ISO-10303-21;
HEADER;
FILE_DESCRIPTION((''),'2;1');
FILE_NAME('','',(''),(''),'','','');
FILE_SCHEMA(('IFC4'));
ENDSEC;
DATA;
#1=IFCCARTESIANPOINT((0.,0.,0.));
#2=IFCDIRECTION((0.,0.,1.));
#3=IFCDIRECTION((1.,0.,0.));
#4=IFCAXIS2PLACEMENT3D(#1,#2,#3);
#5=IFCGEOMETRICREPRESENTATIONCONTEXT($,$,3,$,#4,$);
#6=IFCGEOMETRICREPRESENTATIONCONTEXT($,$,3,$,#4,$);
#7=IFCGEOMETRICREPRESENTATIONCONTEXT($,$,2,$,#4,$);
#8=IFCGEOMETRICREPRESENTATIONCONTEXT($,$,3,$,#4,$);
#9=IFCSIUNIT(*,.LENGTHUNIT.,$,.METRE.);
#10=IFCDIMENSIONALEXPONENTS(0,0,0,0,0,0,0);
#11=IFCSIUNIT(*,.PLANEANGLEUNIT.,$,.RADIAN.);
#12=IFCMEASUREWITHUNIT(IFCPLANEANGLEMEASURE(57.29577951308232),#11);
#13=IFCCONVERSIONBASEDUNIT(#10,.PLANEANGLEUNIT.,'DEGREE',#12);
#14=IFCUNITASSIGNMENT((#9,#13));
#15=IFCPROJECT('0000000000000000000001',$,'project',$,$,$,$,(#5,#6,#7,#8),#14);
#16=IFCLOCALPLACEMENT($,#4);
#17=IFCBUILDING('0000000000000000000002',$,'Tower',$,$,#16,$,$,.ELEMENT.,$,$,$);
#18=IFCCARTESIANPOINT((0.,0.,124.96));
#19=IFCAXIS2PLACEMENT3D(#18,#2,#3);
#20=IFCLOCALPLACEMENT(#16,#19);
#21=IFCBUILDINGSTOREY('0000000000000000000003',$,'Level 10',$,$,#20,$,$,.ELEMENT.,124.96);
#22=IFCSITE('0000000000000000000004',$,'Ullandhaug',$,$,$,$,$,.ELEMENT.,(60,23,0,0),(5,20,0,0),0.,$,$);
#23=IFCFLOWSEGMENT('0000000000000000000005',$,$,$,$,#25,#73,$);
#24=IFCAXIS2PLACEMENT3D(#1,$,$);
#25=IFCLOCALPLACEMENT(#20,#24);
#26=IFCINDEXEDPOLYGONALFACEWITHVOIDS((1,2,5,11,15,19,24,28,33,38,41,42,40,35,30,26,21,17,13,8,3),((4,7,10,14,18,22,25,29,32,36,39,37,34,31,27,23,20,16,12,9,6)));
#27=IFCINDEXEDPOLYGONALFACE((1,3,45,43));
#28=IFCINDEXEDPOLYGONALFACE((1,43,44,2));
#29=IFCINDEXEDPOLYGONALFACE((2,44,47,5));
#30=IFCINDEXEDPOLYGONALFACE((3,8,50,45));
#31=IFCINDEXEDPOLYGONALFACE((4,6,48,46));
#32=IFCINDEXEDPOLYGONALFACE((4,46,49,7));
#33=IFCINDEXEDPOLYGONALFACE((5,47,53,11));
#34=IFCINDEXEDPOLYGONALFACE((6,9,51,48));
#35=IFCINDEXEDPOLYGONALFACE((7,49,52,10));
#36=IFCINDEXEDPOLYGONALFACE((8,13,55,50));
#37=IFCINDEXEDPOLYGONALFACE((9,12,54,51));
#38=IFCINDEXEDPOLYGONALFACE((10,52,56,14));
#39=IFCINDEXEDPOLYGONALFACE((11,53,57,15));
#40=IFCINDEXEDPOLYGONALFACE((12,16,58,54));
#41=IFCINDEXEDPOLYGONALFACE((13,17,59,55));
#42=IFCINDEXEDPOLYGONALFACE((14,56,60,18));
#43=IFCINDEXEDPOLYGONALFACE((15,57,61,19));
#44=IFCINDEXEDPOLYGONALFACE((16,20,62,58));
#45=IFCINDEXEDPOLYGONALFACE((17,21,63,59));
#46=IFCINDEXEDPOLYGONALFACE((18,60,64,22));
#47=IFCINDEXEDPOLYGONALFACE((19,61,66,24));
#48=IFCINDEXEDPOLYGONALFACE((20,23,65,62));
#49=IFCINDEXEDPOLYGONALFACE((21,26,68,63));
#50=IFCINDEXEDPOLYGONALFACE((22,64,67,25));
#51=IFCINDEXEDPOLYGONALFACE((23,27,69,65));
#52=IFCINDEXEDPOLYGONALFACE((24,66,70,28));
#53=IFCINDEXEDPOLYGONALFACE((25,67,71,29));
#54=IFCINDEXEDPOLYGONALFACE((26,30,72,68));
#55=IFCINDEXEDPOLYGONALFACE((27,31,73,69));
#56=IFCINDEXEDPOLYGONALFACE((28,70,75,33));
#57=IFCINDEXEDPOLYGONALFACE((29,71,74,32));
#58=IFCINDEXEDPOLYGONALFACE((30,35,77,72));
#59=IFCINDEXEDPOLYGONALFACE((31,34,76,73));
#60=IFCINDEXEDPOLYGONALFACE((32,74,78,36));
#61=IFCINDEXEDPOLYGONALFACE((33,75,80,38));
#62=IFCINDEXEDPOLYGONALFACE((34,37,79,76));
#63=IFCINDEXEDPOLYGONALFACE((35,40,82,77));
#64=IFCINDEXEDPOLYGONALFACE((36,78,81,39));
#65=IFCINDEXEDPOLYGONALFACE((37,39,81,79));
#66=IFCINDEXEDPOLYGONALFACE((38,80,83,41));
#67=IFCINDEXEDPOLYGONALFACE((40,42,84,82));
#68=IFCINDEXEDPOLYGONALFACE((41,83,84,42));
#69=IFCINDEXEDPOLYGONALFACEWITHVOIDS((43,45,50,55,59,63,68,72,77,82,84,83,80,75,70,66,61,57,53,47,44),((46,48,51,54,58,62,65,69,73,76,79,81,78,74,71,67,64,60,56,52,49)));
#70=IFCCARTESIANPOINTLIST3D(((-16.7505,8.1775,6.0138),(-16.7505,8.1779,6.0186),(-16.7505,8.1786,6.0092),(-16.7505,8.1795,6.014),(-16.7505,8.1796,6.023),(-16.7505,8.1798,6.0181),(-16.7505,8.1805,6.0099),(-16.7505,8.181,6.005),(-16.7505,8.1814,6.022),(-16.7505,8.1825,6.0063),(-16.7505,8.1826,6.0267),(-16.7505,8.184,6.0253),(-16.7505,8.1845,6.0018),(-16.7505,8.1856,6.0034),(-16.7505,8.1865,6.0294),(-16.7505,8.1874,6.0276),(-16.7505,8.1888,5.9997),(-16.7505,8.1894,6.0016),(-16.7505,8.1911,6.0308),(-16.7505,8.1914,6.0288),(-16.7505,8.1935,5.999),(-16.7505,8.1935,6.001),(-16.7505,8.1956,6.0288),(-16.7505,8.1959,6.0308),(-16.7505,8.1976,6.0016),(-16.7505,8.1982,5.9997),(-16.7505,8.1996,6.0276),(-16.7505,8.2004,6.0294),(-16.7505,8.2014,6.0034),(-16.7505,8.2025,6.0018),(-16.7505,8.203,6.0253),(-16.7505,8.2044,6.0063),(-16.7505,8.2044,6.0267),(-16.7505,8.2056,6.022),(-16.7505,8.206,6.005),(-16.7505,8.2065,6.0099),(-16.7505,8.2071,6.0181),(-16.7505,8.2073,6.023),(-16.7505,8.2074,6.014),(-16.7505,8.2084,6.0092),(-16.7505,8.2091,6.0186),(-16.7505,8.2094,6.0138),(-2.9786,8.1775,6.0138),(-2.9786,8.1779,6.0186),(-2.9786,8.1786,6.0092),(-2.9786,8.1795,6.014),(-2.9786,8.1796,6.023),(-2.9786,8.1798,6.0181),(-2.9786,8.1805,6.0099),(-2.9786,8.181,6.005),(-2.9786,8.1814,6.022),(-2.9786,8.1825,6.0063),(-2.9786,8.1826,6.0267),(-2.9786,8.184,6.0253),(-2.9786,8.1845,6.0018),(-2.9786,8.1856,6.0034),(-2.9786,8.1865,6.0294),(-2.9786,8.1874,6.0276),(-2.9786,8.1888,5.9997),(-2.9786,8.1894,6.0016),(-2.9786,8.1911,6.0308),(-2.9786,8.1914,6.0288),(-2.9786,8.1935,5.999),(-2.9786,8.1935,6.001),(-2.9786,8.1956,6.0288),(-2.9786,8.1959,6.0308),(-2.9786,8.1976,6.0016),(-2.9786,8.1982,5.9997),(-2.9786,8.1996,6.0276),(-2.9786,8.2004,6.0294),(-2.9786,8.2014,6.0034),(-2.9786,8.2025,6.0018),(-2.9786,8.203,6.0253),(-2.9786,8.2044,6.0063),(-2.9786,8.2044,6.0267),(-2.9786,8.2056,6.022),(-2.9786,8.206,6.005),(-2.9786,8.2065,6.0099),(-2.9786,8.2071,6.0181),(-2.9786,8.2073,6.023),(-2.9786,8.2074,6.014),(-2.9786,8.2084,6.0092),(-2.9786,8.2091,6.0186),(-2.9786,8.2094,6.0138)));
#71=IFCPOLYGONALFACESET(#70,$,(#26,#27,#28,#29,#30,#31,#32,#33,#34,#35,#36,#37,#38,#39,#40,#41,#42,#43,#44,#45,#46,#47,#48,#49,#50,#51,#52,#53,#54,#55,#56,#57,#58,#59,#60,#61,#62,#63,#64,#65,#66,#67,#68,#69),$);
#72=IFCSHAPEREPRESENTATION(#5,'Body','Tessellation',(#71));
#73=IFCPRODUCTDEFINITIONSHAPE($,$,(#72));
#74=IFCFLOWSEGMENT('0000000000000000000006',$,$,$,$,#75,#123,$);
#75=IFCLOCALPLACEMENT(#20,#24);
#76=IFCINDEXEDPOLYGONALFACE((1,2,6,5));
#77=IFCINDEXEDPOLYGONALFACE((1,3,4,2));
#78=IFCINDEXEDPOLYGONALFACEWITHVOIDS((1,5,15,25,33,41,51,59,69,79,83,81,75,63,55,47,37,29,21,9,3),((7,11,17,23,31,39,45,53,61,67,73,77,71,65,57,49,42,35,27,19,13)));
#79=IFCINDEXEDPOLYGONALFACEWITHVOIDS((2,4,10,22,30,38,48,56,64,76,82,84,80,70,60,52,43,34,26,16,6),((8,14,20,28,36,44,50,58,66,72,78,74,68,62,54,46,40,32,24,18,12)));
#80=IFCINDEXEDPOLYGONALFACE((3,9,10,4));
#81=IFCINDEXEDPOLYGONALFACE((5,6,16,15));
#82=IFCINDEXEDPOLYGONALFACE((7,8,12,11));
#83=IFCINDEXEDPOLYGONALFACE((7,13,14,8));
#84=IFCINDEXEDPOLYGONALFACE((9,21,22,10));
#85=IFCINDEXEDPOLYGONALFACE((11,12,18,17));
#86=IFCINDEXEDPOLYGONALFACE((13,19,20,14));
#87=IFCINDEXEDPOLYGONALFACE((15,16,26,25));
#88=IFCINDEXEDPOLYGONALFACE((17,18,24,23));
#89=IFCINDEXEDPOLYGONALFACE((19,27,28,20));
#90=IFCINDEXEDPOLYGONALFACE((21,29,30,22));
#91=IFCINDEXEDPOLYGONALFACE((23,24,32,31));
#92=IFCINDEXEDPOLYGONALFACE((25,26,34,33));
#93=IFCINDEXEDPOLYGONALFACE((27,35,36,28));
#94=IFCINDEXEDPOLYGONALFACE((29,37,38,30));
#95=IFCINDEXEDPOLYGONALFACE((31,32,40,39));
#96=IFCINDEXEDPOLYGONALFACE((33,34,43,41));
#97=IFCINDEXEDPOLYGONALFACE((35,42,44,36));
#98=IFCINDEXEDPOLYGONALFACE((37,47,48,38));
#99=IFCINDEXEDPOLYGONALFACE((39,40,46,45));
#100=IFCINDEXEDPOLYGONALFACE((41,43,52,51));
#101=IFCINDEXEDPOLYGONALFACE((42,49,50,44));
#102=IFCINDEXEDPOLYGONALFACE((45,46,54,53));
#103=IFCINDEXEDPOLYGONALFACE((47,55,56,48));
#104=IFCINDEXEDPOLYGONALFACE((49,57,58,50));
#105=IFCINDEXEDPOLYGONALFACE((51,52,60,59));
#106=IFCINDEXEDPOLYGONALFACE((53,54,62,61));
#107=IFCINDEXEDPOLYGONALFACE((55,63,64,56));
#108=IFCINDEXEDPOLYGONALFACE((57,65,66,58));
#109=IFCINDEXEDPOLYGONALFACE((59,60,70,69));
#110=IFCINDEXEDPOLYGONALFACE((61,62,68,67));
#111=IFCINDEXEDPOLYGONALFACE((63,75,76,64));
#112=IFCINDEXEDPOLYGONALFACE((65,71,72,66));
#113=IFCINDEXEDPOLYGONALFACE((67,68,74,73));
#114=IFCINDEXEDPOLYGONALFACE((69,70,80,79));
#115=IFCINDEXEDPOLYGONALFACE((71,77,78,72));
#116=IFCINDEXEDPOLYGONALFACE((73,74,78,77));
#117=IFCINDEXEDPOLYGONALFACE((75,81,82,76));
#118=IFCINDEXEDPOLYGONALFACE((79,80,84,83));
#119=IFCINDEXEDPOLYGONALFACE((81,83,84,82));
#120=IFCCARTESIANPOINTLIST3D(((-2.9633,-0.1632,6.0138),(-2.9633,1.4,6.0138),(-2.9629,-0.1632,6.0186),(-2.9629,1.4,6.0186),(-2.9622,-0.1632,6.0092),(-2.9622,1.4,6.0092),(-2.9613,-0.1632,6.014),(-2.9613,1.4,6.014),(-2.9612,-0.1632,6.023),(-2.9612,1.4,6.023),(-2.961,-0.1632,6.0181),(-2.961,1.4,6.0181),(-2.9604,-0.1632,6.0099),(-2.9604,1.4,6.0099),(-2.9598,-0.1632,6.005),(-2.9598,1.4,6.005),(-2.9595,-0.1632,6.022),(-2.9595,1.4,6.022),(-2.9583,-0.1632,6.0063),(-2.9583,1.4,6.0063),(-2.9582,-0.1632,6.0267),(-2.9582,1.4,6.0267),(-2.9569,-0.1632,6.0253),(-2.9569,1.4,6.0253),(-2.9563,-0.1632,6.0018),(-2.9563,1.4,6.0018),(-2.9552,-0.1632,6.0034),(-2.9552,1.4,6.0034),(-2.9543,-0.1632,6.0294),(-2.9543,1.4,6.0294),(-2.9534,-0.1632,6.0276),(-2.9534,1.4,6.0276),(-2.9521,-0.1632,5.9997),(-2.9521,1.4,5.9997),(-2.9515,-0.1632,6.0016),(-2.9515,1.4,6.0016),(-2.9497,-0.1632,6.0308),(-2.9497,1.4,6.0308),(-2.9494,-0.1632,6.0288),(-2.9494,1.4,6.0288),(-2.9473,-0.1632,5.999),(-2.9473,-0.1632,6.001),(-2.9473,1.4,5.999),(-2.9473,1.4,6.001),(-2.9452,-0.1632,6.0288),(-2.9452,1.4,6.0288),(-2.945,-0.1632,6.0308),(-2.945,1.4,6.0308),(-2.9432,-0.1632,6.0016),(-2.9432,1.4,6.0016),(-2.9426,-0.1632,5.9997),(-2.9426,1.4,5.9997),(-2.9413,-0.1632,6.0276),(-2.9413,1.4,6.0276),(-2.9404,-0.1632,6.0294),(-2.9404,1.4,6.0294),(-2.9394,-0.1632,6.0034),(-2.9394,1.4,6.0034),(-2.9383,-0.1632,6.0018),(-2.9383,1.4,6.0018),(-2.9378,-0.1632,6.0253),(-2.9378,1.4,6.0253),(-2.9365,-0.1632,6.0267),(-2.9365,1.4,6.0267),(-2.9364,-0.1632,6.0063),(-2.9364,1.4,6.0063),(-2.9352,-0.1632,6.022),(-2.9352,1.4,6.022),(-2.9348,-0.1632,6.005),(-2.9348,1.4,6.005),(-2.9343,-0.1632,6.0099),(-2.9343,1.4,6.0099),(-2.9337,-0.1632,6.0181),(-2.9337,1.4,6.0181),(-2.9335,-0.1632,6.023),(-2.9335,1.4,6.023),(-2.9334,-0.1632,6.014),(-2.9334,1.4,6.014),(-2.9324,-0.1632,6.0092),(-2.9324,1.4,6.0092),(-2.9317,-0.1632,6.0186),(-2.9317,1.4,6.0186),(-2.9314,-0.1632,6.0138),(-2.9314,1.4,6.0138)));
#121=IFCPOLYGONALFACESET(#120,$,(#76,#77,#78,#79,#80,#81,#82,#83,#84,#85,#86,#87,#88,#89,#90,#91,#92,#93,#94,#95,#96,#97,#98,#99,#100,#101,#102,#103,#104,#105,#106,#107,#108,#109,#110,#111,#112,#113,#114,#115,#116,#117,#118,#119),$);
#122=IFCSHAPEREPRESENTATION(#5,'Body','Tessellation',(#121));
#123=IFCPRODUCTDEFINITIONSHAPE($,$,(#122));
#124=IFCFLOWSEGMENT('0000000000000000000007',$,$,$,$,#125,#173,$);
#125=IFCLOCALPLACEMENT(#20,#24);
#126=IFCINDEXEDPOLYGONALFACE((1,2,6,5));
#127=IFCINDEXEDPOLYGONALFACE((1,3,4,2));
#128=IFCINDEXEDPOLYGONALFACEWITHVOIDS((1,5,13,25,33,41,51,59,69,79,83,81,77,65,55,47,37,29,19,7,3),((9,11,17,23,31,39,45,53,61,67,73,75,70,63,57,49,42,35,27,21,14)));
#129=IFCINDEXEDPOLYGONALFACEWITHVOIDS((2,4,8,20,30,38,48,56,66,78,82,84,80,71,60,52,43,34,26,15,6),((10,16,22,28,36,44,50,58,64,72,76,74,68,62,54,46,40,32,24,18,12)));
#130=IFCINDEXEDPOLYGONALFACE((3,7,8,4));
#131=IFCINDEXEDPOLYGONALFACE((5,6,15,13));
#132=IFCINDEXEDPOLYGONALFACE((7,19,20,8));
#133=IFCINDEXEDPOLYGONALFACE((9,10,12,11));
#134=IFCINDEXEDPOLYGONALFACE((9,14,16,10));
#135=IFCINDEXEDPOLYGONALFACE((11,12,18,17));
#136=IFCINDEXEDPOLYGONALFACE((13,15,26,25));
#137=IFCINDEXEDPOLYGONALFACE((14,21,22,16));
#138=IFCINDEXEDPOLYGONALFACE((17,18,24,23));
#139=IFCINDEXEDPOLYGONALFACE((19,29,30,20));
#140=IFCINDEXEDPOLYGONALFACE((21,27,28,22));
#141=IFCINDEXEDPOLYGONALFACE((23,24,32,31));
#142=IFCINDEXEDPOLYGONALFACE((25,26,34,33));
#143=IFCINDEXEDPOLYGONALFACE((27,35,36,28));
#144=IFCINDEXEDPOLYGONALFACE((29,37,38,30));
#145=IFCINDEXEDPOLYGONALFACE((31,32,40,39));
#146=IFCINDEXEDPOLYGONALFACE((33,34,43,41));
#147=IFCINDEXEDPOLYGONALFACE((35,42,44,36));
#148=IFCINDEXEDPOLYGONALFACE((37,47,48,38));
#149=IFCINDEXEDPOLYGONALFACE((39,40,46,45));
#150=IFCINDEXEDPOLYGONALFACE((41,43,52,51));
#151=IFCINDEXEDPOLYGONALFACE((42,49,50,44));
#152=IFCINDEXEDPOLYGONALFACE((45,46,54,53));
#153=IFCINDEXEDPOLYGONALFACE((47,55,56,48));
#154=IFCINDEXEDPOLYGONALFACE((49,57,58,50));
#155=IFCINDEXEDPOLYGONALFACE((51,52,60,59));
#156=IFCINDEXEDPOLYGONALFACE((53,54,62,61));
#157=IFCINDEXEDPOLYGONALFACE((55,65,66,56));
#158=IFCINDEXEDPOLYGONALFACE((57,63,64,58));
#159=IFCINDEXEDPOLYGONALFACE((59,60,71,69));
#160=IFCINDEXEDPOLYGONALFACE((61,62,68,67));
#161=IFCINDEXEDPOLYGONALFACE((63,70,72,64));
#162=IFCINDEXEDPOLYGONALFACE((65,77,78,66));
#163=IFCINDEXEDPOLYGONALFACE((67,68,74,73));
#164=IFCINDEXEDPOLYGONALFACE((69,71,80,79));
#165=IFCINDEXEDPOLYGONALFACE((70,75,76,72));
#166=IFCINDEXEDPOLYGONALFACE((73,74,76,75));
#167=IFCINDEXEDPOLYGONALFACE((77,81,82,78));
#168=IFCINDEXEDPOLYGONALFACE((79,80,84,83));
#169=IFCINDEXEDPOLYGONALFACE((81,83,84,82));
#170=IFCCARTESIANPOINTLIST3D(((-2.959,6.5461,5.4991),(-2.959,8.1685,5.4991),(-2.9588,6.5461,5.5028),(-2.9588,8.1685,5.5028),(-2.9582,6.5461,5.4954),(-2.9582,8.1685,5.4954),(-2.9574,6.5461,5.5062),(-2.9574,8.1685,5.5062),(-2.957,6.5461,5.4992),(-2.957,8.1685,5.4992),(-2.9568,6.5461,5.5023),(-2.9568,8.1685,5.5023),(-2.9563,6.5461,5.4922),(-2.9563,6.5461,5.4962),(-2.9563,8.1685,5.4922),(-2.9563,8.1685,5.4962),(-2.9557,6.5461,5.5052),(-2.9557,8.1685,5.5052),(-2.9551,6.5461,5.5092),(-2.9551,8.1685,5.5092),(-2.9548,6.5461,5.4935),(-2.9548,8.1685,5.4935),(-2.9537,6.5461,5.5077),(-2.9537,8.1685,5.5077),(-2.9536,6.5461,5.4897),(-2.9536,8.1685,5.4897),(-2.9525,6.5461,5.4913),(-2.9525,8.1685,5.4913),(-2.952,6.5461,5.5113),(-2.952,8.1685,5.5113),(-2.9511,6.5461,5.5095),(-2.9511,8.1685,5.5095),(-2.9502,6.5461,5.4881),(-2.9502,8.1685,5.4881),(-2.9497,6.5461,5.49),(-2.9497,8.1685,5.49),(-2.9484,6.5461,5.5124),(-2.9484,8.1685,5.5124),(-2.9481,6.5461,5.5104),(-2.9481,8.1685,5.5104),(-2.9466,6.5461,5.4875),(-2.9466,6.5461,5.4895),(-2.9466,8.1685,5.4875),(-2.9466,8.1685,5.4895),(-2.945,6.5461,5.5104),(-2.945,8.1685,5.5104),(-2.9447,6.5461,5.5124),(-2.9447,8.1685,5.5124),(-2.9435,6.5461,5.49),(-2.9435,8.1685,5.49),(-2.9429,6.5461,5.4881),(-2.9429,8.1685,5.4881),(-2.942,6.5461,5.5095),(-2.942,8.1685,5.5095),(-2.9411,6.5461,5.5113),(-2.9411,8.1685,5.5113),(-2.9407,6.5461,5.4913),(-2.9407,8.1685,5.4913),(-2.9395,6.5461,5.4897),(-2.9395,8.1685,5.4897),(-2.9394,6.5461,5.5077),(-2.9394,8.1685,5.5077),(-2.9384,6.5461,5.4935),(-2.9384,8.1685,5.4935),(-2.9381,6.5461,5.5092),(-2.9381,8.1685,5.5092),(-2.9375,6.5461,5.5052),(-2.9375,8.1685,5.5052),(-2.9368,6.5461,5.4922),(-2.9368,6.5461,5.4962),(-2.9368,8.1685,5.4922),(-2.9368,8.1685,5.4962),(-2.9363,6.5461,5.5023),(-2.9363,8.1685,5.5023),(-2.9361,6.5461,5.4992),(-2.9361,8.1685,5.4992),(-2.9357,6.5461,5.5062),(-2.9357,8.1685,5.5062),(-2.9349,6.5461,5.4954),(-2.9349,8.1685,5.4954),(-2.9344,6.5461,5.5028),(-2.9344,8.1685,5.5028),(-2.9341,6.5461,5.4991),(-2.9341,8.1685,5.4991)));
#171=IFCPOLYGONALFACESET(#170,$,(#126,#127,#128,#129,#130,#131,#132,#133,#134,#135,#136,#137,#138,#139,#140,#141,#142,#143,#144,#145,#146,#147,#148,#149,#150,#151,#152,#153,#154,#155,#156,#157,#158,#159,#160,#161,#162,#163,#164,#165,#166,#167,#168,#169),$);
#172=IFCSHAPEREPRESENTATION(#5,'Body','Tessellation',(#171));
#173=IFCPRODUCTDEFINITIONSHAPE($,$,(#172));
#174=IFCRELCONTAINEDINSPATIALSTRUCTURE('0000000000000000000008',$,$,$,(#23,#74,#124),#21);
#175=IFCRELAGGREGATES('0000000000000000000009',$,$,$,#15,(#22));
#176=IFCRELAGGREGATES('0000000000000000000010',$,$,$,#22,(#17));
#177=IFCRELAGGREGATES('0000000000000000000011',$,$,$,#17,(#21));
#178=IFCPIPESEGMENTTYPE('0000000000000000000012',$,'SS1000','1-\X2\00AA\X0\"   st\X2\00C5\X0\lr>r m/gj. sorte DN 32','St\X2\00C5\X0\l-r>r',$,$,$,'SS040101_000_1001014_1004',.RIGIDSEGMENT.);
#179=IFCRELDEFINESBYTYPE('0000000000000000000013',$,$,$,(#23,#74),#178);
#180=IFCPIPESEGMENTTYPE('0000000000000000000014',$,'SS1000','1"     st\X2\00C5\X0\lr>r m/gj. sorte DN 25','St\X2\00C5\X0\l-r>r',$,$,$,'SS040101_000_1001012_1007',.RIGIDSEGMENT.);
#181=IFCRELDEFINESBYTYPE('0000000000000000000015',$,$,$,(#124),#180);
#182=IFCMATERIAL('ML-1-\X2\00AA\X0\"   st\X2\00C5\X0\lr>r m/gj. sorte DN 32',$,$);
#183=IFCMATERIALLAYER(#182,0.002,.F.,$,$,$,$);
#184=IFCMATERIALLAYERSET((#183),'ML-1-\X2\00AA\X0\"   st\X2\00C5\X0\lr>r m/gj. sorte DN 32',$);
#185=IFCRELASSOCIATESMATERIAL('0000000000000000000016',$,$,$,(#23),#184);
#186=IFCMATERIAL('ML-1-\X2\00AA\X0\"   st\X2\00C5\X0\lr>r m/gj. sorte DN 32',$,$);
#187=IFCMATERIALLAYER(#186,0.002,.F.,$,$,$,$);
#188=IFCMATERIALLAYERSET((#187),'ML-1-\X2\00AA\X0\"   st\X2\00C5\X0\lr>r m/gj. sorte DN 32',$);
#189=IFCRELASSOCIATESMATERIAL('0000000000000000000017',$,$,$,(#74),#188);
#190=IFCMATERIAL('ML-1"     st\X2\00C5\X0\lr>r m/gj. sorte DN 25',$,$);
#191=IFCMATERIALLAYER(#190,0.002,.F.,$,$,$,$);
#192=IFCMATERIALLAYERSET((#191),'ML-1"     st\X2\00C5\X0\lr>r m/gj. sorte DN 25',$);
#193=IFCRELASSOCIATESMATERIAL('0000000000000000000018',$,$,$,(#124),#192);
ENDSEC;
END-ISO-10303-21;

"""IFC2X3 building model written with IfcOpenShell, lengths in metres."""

from ifc_helpers import new_model, entity, si_unit, converted_unit, frame, origin_with_axes, origin_2d_with_axis, place, context, project, spatial, hollow_circle, extrude, material, layer, layer_set, layer_usage, type_object, element, save


model = new_model("IFC2X3")

# Units and contexts
context_of_model_1 = context(None, 3, world=origin_with_axes())
context_of_model_2 = context(None, 3, world=origin_with_axes())
context_of_model_3 = context(None, 2, world=origin_with_axes())
context_of_model_4 = context(None, 3, world=origin_with_axes())
ifc_project = project(units=[si_unit("LENGTHUNIT", "METRE"), converted_unit("PLANEANGLEUNIT", "DEGREE", entity("IfcPlaneAngleMeasure", 57.29577951308232), si_unit("PLANEANGLEUNIT", "RADIAN"), dimensions=[0, 0, 0, 0, 0, 0, 0])], contexts=[context_of_model_1, context_of_model_2, context_of_model_3, context_of_model_4])

# Site, building, storey
site = spatial("IfcSite", under=ifc_project, Name="Ullandhaug", CompositionType="ELEMENT", RefLatitude=(60, 23, 0, 0), RefLongitude=(5, 20, 0, 0), RefElevation=0.0)
building_placement = place(None, origin_with_axes())
building = spatial("IfcBuilding", under=site, at=building_placement, Name="Tower", CompositionType="ELEMENT")
storey_placement = place(building_placement, frame((0.0, 0.0, 124.96), z_axis=(0.0, 0.0, 1.0), x_axis=(1.0, 0.0, 0.0)))
storey = spatial("IfcBuildingStorey", under=building, at=storey_placement, Name="Level 10", CompositionType="ELEMENT", Elevation=124.96)

# Flow segments
pipe_segment_type_1 = type_object("IfcPipeSegmentType", Name="SS1000", Description="1-ª\"   stÅlr>r m/gj. sorte DN 32", ApplicableOccurrence="StÅl-r>r", ElementType="SS040101_000_1001014_1004", PredefinedType="RIGIDSEGMENT")
ifc_material_1 = material(Name="ML-1-ª\"   stÅlr>r m/gj. sorte DN 32")
ifc_layer_1 = layer(ifc_material_1, 0.002, ventilated=False)
ifc_layer_set_1 = layer_set([ifc_layer_1], Name="ML-1-ª\"   stÅlr>r m/gj. sorte DN 32")
ifc_layer_usage_1 = layer_usage(ifc_layer_set_1, "AXIS2", "POSITIVE", 0.0)
flow_segment_1_placement = place(storey_placement, frame((-2.9786, 8.1935, 6.015), z_axis=(-1.0, 0.0, 0.0), x_axis=(0.0, 0.0, -1.0)))
element("IfcFlowSegment", 1, at=flow_segment_1_placement, inside=storey, type_object=pipe_segment_type_1, material=ifc_layer_usage_1, context=context_of_model_1, shape_type="SweptSolid", body=[
    extrude(hollow_circle(Radius=0.016, WallThickness=0.002, at=origin_2d_with_axis()), origin_with_axes(), (0.0, 0.0, 1.0), 13.7719),
])
ifc_material_2 = material(Name="ML-1-ª\"   stÅlr>r m/gj. sorte DN 32")
ifc_layer_2 = layer(ifc_material_2, 0.002, ventilated=False)
ifc_layer_set_2 = layer_set([ifc_layer_2], Name="ML-1-ª\"   stÅlr>r m/gj. sorte DN 32")
ifc_layer_usage_2 = layer_usage(ifc_layer_set_2, "AXIS2", "POSITIVE", 0.0)
flow_segment_2_placement = place(storey_placement, frame((-2.9473, -0.1632, 6.015), z_axis=(0.0, 1.0, 0.0), x_axis=(0.0, 0.0, -1.0)))
element("IfcFlowSegment", 2, at=flow_segment_2_placement, inside=storey, type_object=pipe_segment_type_1, material=ifc_layer_usage_2, context=context_of_model_1, shape_type="SweptSolid", body=[
    extrude(hollow_circle(Radius=0.016, WallThickness=0.002, at=origin_2d_with_axis()), origin_with_axes(), (0.0, 0.0, 1.0), 1.5632),
])
ifc_material_3 = material(Name="ML-1\"     stÅlr>r m/gj. sorte DN 25")
ifc_layer_3 = layer(ifc_material_3, 0.002, ventilated=False)
ifc_layer_set_3 = layer_set([ifc_layer_3], Name="ML-1\"     stÅlr>r m/gj. sorte DN 25")
ifc_layer_usage_3 = layer_usage(ifc_layer_set_3, "AXIS2", "POSITIVE", 0.0)
pipe_segment_type_2 = type_object("IfcPipeSegmentType", Name="SS1000", Description="1\"     stÅlr>r m/gj. sorte DN 25", ApplicableOccurrence="StÅl-r>r", ElementType="SS040101_000_1001012_1007", PredefinedType="RIGIDSEGMENT")
flow_segment_3_placement = place(storey_placement, frame((-2.9466, 6.5461, 5.5), z_axis=(0.0, 1.0, 0.0), x_axis=(0.0, 0.0, -1.0)))
element("IfcFlowSegment", 3, at=flow_segment_3_placement, inside=storey, type_object=pipe_segment_type_2, material=ifc_layer_usage_3, context=context_of_model_1, shape_type="SweptSolid", body=[
    extrude(hollow_circle(Radius=0.0125, WallThickness=0.002, at=origin_2d_with_axis()), origin_with_axes(), (0.0, 0.0, 1.0), 1.6224),
])

save(model, "model.ifc")
